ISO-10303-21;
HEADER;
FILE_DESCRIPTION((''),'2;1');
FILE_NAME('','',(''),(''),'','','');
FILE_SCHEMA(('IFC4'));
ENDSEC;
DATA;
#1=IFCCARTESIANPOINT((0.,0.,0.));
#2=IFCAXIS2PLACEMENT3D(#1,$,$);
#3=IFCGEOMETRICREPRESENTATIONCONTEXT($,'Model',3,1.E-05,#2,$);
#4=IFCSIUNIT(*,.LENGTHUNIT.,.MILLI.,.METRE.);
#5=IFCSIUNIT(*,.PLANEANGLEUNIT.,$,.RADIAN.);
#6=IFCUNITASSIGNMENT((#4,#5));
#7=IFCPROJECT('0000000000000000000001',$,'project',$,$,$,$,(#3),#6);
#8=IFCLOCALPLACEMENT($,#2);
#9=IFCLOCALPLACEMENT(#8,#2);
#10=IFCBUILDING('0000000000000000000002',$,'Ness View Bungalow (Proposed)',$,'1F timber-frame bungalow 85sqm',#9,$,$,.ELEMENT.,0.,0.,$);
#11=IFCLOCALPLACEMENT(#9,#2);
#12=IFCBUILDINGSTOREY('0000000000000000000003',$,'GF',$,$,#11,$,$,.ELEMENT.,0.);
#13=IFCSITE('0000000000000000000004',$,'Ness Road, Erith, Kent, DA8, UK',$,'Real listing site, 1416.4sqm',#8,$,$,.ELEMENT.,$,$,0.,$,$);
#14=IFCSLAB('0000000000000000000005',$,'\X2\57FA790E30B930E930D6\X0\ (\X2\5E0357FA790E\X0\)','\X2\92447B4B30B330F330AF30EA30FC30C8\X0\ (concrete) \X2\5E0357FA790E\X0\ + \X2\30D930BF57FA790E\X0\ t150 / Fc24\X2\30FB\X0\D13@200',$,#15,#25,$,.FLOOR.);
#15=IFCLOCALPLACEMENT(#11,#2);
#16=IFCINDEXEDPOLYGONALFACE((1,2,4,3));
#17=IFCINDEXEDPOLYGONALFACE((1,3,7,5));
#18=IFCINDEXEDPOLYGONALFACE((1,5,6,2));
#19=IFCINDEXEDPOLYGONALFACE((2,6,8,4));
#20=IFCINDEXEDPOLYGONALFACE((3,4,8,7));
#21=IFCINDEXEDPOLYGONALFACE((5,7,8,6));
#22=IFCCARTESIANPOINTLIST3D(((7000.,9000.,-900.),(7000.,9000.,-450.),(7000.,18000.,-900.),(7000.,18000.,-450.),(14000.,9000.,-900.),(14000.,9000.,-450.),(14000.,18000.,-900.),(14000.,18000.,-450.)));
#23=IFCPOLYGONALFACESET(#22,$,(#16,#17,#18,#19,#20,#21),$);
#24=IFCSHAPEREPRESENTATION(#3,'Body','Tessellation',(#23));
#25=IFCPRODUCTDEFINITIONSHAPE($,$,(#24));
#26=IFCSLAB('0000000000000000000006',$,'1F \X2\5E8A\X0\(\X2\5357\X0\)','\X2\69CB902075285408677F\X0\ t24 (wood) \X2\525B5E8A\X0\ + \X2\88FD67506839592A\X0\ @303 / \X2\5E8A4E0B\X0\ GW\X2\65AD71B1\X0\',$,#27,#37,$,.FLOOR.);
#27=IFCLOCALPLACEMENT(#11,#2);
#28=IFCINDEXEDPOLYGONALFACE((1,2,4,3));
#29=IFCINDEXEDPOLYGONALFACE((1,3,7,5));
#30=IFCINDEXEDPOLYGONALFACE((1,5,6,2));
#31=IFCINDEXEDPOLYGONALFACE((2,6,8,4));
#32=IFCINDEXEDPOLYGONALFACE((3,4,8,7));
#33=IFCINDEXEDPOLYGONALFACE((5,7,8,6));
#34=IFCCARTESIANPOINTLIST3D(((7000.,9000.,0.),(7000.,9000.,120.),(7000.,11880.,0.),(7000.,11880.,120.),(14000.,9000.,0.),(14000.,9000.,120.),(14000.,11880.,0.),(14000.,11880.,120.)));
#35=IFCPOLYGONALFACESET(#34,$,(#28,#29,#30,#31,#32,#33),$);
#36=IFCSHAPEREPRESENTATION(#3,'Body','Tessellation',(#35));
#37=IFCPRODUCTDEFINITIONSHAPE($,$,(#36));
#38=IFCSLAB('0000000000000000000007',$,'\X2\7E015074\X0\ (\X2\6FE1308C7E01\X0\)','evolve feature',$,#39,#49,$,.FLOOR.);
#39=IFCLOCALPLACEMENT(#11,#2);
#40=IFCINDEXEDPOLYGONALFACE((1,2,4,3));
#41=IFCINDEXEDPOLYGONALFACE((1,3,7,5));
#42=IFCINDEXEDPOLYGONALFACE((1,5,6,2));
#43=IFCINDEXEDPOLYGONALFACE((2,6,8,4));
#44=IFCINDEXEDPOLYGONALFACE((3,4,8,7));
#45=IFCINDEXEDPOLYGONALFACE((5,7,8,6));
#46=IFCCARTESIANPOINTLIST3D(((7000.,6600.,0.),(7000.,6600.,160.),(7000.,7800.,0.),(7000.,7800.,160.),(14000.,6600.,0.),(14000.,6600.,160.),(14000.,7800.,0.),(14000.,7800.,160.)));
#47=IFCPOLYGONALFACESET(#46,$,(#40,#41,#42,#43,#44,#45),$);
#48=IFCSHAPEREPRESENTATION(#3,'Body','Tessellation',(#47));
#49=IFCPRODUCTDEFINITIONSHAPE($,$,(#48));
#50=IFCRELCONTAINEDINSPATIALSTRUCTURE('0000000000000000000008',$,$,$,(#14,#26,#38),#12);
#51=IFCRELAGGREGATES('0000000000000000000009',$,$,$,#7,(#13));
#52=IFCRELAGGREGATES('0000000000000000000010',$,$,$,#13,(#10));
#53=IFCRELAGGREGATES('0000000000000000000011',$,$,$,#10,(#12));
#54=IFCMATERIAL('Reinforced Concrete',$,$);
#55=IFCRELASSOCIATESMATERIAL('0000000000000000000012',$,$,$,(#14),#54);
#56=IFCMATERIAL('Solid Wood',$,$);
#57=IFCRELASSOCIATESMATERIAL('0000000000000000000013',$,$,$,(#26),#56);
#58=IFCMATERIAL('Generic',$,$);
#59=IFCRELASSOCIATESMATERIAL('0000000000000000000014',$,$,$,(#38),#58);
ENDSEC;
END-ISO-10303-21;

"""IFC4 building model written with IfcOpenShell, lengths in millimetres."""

from ifc_helpers import new_model, si_unit, frame, frame_2d, origin, place, context, project, spatial, rectangle, extrude, material, element, save


model = new_model("IFC4")

# Units and contexts
model_context = context("Model", 3, precision=1e-05, world=origin())
ifc_project = project(units=[si_unit("LENGTHUNIT", "METRE", prefix="MILLI"), si_unit("PLANEANGLEUNIT", "RADIAN")], contexts=[model_context])

# Site, building, storey
site_placement = place(None, origin())
site = spatial("IfcSite", under=ifc_project, at=site_placement, Name="Ness Road, Erith, Kent, DA8, UK", ObjectType="Real listing site, 1416.4sqm", CompositionType="ELEMENT", RefElevation=0.0)
building_placement = place(site_placement, origin())
building = spatial("IfcBuilding", under=site, at=building_placement, Name="Ness View Bungalow (Proposed)", ObjectType="1F timber-frame bungalow 85sqm", CompositionType="ELEMENT", ElevationOfRefHeight=0.0, ElevationOfTerrain=0.0)
storey_placement = place(building_placement, origin())
storey = spatial("IfcBuildingStorey", under=building, at=storey_placement, Name="GF", CompositionType="ELEMENT", Elevation=0.0)

# Slabs
ifc_material_1 = material(Name="Reinforced Concrete")
slab_1_placement = place(storey_placement, frame((3500.0, 4500.0, -450.0)))
element("IfcSlab", 1, at=slab_1_placement, inside=storey, material=ifc_material_1, Name="基礎スラブ (布基礎)", Description="鉄筋コンクリート (concrete) 布基礎 + ベタ基礎 t150 / Fc24・D13@200", PredefinedType="FLOOR", context=model_context, shape_type="SweptSolid", body=[
    extrude(rectangle(XDim=7000.0, YDim=9000.0, at=frame_2d((3500.0, 4500.0))), frame((3500.0, 4500.0, -450.0)), (0.0, 0.0, 1.0), 450.0),
])
ifc_material_2 = material(Name="Solid Wood")
slab_2_placement = place(storey_placement, frame((3500.0, 4500.0, 0.0)))
element("IfcSlab", 2, at=slab_2_placement, inside=storey, material=ifc_material_2, Name="1F 床(南)", Description="構造用合板 t24 (wood) 剛床 + 製材根太 @303 / 床下 GW断熱", PredefinedType="FLOOR", context=model_context, shape_type="SweptSolid", body=[
    extrude(rectangle(XDim=7000.0, YDim=2880.0, at=frame_2d((3500.0, 1440.0))), frame((3500.0, 4500.0, 0.0)), (0.0, 0.0, 1.0), 120.0),
])
ifc_material_3 = material(Name="Generic")
slab_3_placement = place(storey_placement, frame((3500.0, 3300.0, 0.0)))
element("IfcSlab", 3, at=slab_3_placement, inside=storey, material=ifc_material_3, Name="縁側 (濡れ縁)", Description="evolve feature", PredefinedType="FLOOR", context=model_context, shape_type="SweptSolid", body=[
    extrude(rectangle(XDim=7000.0, YDim=1200.0, at=frame_2d((3500.0, 600.0))), frame((3500.0, 3300.0, 0.0)), (0.0, 0.0, 1.0), 160.0),
])

save(model, "model.ifc")
